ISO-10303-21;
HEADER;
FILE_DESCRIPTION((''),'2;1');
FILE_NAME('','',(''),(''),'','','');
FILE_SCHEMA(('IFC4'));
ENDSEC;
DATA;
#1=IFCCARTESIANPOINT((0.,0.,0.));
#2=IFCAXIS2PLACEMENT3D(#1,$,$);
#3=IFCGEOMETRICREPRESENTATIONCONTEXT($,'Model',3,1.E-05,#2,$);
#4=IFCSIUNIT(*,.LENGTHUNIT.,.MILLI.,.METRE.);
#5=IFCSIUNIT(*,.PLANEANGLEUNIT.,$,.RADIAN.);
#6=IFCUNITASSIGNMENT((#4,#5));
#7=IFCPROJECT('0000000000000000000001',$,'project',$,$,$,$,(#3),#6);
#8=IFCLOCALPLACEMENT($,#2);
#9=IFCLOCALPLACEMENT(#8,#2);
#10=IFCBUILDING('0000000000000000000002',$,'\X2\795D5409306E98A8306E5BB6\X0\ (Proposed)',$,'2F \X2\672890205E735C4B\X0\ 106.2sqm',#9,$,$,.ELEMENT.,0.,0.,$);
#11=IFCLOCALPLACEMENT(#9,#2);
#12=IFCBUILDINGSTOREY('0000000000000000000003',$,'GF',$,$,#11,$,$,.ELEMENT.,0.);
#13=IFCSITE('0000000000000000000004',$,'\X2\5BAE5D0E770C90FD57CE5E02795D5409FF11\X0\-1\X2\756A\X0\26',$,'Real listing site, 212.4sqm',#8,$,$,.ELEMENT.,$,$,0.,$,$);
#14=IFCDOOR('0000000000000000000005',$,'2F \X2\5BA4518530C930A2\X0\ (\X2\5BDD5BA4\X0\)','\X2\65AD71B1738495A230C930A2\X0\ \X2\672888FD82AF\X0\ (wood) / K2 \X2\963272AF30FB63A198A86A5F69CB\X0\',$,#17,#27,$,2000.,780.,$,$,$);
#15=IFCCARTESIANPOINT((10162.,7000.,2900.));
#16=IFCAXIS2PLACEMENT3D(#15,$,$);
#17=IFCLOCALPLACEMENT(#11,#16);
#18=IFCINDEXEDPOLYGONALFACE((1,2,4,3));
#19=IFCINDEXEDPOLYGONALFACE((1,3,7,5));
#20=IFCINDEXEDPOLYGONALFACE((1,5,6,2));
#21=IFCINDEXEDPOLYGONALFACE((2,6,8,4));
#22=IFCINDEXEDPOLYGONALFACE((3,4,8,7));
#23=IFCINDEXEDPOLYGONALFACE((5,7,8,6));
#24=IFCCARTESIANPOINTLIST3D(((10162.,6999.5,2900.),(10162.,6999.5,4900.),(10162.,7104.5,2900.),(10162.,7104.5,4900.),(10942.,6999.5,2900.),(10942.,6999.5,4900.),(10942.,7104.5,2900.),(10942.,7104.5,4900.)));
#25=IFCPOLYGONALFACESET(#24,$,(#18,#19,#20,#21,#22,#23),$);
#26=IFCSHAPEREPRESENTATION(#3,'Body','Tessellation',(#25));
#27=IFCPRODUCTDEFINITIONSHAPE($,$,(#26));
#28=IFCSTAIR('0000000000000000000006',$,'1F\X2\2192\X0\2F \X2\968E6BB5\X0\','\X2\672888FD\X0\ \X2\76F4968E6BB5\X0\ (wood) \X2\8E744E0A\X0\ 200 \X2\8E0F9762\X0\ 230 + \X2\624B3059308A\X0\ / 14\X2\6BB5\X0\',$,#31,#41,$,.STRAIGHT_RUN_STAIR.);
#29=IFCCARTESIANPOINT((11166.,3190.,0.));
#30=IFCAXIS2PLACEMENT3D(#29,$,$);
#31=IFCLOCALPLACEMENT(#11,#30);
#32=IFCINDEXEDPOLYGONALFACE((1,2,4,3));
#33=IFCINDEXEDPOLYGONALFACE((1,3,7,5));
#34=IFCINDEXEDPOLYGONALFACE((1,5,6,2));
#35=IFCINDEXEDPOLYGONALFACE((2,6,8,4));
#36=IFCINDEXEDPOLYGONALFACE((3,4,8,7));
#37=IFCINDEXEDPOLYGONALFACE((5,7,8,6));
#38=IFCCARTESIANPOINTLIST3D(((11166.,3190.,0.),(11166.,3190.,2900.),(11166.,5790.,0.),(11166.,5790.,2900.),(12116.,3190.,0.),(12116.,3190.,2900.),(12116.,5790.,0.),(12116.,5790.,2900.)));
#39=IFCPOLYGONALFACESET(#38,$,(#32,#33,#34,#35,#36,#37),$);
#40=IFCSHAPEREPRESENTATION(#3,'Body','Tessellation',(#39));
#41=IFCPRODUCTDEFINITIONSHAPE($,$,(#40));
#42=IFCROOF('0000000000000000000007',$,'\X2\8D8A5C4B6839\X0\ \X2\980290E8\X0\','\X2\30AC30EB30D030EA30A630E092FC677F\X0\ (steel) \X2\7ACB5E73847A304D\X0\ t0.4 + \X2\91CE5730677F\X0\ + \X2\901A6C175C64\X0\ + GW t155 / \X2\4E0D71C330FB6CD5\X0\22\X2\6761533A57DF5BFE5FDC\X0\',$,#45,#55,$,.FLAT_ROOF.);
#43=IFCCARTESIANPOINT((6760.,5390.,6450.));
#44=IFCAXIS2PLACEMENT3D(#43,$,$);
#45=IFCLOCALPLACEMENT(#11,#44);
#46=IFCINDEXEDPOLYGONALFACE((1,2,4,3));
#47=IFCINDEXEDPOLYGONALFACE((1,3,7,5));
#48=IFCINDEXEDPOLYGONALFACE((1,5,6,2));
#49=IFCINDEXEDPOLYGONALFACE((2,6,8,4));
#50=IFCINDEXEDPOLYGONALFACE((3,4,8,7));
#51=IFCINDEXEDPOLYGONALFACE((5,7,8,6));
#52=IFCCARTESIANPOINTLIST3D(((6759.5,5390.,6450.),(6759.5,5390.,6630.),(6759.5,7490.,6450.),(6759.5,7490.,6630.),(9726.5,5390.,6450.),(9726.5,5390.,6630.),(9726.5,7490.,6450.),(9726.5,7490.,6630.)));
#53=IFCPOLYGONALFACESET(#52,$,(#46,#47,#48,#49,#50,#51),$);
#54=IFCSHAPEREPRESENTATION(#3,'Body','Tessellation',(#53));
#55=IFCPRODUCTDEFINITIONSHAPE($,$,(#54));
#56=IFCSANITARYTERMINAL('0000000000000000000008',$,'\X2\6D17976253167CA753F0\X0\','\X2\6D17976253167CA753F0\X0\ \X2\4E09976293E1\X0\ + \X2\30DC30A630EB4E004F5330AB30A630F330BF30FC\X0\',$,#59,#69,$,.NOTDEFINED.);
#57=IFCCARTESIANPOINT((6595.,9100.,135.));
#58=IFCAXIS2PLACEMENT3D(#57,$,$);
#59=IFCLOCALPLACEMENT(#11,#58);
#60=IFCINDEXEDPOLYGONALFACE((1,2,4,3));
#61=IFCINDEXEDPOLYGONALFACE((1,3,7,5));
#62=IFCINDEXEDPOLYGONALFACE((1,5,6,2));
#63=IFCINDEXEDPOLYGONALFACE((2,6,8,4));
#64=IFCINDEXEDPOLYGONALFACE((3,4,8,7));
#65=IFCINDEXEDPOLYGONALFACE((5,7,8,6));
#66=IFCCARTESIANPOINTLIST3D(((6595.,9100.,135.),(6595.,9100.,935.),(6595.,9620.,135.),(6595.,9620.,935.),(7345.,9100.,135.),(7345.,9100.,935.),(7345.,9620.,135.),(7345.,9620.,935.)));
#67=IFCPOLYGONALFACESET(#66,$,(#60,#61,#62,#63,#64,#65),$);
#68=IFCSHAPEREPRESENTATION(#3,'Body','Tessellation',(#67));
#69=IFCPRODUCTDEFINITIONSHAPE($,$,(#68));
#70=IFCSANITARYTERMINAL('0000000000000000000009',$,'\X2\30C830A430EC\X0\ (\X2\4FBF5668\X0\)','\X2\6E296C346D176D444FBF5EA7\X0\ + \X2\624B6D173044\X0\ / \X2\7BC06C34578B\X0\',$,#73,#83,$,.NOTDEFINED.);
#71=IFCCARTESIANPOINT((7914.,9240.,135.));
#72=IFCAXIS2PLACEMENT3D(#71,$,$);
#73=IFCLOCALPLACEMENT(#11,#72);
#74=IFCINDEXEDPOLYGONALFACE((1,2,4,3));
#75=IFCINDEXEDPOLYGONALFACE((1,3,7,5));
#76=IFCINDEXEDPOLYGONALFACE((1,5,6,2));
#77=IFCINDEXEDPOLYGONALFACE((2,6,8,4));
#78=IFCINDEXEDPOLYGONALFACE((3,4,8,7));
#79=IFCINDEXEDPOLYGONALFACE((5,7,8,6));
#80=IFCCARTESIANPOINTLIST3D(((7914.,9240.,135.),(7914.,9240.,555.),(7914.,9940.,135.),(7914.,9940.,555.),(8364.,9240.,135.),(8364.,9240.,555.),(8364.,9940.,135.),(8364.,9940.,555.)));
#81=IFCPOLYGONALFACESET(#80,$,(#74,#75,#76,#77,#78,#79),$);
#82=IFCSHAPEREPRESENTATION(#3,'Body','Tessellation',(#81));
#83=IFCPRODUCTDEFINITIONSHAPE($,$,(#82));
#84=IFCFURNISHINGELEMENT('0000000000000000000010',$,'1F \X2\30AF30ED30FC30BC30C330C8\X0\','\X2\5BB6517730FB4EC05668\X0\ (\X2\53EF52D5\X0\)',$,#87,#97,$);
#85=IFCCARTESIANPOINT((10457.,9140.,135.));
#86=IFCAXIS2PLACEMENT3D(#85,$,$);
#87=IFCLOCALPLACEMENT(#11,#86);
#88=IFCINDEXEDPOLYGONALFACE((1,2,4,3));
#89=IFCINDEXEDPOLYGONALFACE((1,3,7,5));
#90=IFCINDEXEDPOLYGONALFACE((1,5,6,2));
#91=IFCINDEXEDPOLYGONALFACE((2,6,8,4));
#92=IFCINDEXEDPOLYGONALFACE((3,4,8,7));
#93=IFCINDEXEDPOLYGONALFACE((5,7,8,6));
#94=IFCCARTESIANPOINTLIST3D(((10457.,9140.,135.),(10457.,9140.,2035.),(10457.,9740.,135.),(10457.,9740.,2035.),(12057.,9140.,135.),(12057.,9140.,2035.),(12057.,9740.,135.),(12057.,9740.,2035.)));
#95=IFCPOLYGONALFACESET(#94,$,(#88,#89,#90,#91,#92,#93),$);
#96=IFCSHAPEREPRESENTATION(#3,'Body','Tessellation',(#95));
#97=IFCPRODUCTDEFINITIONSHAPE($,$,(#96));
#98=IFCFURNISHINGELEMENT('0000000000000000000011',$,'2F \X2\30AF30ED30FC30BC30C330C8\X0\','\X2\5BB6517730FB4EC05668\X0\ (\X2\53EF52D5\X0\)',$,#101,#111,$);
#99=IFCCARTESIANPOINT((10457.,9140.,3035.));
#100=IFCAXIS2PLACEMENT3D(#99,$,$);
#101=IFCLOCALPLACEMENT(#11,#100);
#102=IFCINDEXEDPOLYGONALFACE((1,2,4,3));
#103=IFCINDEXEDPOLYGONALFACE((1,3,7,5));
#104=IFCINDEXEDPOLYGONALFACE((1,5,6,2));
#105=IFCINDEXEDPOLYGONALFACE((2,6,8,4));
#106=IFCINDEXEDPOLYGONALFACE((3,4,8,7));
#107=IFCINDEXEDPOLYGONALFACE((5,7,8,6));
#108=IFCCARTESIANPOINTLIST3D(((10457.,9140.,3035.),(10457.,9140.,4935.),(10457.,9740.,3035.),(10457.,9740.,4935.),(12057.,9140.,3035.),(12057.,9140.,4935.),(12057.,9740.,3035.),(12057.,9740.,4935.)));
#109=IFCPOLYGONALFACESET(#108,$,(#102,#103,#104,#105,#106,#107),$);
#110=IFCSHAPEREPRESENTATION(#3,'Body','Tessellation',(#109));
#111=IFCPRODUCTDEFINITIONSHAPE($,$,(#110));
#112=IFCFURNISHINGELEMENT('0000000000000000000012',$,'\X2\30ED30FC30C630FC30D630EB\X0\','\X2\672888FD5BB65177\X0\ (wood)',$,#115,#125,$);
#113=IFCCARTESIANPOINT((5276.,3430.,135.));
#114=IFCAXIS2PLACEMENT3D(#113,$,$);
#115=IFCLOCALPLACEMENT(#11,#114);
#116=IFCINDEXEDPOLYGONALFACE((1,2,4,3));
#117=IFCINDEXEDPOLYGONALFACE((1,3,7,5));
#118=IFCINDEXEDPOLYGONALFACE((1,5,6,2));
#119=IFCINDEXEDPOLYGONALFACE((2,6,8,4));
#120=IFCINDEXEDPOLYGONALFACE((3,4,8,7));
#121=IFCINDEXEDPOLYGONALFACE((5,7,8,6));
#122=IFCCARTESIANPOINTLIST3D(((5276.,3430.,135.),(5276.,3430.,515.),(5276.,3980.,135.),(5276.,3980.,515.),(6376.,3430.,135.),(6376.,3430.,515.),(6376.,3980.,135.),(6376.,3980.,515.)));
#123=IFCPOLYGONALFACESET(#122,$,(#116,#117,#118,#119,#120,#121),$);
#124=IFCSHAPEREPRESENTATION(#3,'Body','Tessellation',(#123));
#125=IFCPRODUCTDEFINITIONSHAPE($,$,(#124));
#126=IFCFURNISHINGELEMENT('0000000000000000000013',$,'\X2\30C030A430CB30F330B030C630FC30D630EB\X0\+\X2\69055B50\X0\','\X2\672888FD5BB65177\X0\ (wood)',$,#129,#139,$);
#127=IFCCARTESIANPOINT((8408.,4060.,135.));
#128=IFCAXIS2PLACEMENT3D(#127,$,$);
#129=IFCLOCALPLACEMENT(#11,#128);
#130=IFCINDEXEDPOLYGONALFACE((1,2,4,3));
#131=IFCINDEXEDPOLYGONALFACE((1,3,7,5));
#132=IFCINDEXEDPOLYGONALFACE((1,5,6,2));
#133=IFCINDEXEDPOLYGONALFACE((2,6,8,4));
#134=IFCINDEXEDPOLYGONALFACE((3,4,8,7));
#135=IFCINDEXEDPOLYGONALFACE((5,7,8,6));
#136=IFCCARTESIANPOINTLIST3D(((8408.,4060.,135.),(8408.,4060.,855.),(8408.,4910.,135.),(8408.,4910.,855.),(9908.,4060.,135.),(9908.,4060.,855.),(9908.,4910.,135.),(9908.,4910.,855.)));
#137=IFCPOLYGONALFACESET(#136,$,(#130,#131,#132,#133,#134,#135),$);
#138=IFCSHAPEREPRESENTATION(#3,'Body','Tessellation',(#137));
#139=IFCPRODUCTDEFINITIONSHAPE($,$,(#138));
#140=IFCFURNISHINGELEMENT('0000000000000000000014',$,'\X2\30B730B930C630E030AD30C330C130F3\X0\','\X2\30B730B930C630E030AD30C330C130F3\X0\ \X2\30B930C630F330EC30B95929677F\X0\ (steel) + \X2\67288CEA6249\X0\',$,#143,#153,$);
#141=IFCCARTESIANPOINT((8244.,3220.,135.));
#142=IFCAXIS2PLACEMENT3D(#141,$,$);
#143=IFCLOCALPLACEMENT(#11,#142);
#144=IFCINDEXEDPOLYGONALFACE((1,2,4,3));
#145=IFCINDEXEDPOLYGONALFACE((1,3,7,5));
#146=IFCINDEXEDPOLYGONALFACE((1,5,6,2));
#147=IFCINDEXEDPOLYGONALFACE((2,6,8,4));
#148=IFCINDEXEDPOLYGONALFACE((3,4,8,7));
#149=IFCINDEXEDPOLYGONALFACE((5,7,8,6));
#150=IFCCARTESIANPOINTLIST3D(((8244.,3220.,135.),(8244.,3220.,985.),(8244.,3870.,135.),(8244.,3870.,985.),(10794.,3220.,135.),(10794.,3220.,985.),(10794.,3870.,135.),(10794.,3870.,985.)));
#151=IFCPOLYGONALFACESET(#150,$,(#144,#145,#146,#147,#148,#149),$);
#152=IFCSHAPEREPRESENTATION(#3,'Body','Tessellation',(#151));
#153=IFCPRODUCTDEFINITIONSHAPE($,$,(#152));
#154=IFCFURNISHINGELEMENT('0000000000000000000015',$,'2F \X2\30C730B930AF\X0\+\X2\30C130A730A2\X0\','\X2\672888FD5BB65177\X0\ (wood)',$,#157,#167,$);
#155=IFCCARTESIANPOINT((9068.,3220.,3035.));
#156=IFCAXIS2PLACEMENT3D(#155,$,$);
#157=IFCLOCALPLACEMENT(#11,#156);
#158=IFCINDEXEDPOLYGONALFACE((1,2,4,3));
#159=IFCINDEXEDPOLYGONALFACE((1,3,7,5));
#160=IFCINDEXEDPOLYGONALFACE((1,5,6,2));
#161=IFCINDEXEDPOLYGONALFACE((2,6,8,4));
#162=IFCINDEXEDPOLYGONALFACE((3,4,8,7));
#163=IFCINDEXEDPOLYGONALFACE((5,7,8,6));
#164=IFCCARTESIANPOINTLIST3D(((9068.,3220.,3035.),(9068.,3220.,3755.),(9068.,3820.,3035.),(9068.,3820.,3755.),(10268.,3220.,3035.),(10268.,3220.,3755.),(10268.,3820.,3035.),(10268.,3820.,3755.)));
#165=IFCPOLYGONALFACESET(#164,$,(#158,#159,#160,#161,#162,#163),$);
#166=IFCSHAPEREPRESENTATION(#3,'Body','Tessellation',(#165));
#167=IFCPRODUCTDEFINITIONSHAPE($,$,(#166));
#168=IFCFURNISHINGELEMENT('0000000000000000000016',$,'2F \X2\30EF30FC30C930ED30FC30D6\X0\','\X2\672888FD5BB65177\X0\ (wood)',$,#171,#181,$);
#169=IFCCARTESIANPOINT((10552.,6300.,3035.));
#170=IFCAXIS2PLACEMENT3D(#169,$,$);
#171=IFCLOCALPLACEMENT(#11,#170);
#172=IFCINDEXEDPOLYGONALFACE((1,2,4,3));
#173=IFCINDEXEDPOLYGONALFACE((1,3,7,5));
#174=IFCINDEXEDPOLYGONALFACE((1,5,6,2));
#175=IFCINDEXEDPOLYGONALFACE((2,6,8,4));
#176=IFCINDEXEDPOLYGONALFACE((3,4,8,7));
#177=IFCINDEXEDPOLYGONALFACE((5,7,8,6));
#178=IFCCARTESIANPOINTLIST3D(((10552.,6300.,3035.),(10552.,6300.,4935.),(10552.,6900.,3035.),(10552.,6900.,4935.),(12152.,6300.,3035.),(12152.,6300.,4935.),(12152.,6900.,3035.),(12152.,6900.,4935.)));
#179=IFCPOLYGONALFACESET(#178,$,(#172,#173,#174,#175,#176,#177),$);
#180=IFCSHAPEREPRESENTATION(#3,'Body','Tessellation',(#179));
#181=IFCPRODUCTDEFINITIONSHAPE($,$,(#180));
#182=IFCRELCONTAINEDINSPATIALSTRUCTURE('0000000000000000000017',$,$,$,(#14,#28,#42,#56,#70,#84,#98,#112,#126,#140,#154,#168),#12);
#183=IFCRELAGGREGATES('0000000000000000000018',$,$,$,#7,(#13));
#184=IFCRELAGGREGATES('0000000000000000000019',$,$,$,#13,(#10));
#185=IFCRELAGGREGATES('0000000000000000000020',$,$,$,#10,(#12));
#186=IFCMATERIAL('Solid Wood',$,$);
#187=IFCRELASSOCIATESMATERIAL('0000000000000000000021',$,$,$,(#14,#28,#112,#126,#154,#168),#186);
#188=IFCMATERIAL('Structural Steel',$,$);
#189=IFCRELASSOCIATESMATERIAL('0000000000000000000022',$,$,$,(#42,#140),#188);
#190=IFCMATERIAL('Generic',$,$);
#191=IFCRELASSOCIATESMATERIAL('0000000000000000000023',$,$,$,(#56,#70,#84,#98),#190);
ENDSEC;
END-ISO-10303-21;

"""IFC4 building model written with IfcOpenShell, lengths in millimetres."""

from ifc_helpers import new_model, si_unit, frame, frame_2d, origin, place, context, project, spatial, rectangle, extrude, material, element, save


model = new_model("IFC4")

# Units and contexts
model_context = context("Model", 3, precision=1e-05, world=origin())
ifc_project = project(units=[si_unit("LENGTHUNIT", "METRE", prefix="MILLI"), si_unit("PLANEANGLEUNIT", "RADIAN")], contexts=[model_context])

# Site, building, storey
site_placement = place(None, origin())
site = spatial("IfcSite", under=ifc_project, at=site_placement, Name="宮崎県都城市祝吉１-1番26", ObjectType="Real listing site, 212.4sqm", CompositionType="ELEMENT", RefElevation=0.0)
building_placement = place(site_placement, origin())
building = spatial("IfcBuilding", under=site, at=building_placement, Name="祝吉の風の家 (Proposed)", ObjectType="2F 木造平屋 106.2sqm", CompositionType="ELEMENT", ElevationOfRefHeight=0.0, ElevationOfTerrain=0.0)
storey_placement = place(building_placement, origin())
storey = spatial("IfcBuildingStorey", under=building, at=storey_placement, Name="GF", CompositionType="ELEMENT", Elevation=0.0)

# Shared definitions
ifc_material_1 = material(Name="Solid Wood")

# Door
door_1_placement = place(storey_placement, frame((10162.0, 7000.0, 2900.0)))
element("IfcDoor", 1, at=door_1_placement, inside=storey, material=ifc_material_1, Name="2F 室内ドア (寝室)", Description="断熱玄関ドア 木製芯 (wood) / K2 防犯・採風機構", OverallHeight=2000.0, OverallWidth=780.0, context=model_context, shape_type="SweptSolid", body=[
    extrude(rectangle(XDim=780.0, YDim=105.0, at=frame_2d((390.0, 52.0))), frame((10162.0, 7000.0, 2900.0)), (0.0, 0.0, 1.0), 2000.0),
])

# Stair
stair_placement = place(storey_placement, frame((11166.0, 3190.0, 0.0)))
element("IfcStair", 2, at=stair_placement, inside=storey, material=ifc_material_1, Name="1F→2F 階段", Description="木製 直階段 (wood) 蹴上 200 踏面 230 + 手すり / 14段", PredefinedType="STRAIGHT_RUN_STAIR", context=model_context, shape_type="SweptSolid", body=[
    extrude(rectangle(XDim=950.0, YDim=2600.0, at=frame_2d((475.0, 1300.0))), frame((11166.0, 3190.0, 0.0)), (0.0, 0.0, 1.0), 2900.0),
])

# Roof
ifc_material_2 = material(Name="Structural Steel")
roof_placement = place(storey_placement, frame((6760.0, 5390.0, 6450.0)))
element("IfcRoof", 3, at=roof_placement, inside=storey, material=ifc_material_2, Name="越屋根 頂部", Description="ガルバリウム鋼板 (steel) 立平葺き t0.4 + 野地板 + 通気層 + GW t155 / 不燃・法22条区域対応", PredefinedType="FLAT_ROOF", context=model_context, shape_type="SweptSolid", body=[
    extrude(rectangle(XDim=2967.0, YDim=2100.0, at=frame_2d((1483.0, 1050.0))), frame((6760.0, 5390.0, 6450.0)), (0.0, 0.0, 1.0), 180.0),
])

# Sanitary terminals
ifc_material_3 = material(Name="Generic")
sanitary_terminal_1_placement = place(storey_placement, frame((6595.0, 9100.0, 135.0)))
element("IfcSanitaryTerminal", 4, at=sanitary_terminal_1_placement, inside=storey, material=ifc_material_3, Name="洗面化粧台", Description="洗面化粧台 三面鏡 + ボウル一体カウンター", PredefinedType="NOTDEFINED", context=model_context, shape_type="SweptSolid", body=[
    extrude(rectangle(XDim=750.0, YDim=520.0, at=frame_2d((375.0, 260.0))), frame((6595.0, 9100.0, 135.0)), (0.0, 0.0, 1.0), 800.0),
])
sanitary_terminal_2_placement = place(storey_placement, frame((7914.0, 9240.0, 135.0)))
element("IfcSanitaryTerminal", 5, at=sanitary_terminal_2_placement, inside=storey, material=ifc_material_3, Name="トイレ (便器)", Description="温水洗浄便座 + 手洗い / 節水型", PredefinedType="NOTDEFINED", context=model_context, shape_type="SweptSolid", body=[
    extrude(rectangle(XDim=450.0, YDim=700.0, at=frame_2d((225.0, 350.0))), frame((7914.0, 9240.0, 135.0)), (0.0, 0.0, 1.0), 420.0),
])

# Furnishing elements
furnishing_1_placement = place(storey_placement, frame((10457.0, 9140.0, 135.0)))
element("IfcFurnishingElement", 6, at=furnishing_1_placement, inside=storey, material=ifc_material_3, Name="1F クローゼット", Description="家具・什器 (可動)", context=model_context, shape_type="SweptSolid", body=[
    extrude(rectangle(XDim=1600.0, YDim=600.0, at=frame_2d((800.0, 300.0))), frame((10457.0, 9140.0, 135.0)), (0.0, 0.0, 1.0), 1900.0),
])
furnishing_2_placement = place(storey_placement, frame((10457.0, 9140.0, 3035.0)))
element("IfcFurnishingElement", 7, at=furnishing_2_placement, inside=storey, material=ifc_material_3, Name="2F クローゼット", Description="家具・什器 (可動)", context=model_context, shape_type="SweptSolid", body=[
    extrude(rectangle(XDim=1600.0, YDim=600.0, at=frame_2d((800.0, 300.0))), frame((10457.0, 9140.0, 3035.0)), (0.0, 0.0, 1.0), 1900.0),
])
furnishing_3_placement = place(storey_placement, frame((5276.0, 3430.0, 135.0)))
element("IfcFurnishingElement", 8, at=furnishing_3_placement, inside=storey, material=ifc_material_1, Name="ローテーブル", Description="木製家具 (wood)", context=model_context, shape_type="SweptSolid", body=[
    extrude(rectangle(XDim=1100.0, YDim=550.0, at=frame_2d((550.0, 275.0))), frame((5276.0, 3430.0, 135.0)), (0.0, 0.0, 1.0), 380.0),
])
furnishing_4_placement = place(storey_placement, frame((8408.0, 4060.0, 135.0)))
element("IfcFurnishingElement", 9, at=furnishing_4_placement, inside=storey, material=ifc_material_1, Name="ダイニングテーブル+椅子", Description="木製家具 (wood)", context=model_context, shape_type="SweptSolid", body=[
    extrude(rectangle(XDim=1500.0, YDim=850.0, at=frame_2d((750.0, 425.0))), frame((8408.0, 4060.0, 135.0)), (0.0, 0.0, 1.0), 720.0),
])
furnishing_5_placement = place(storey_placement, frame((8244.0, 3220.0, 135.0)))
element("IfcFurnishingElement", 10, at=furnishing_5_placement, inside=storey, material=ifc_material_2, Name="システムキッチン", Description="システムキッチン ステンレス天板 (steel) + 木質扉", context=model_context, shape_type="SweptSolid", body=[
    extrude(rectangle(XDim=2550.0, YDim=650.0, at=frame_2d((1275.0, 325.0))), frame((8244.0, 3220.0, 135.0)), (0.0, 0.0, 1.0), 850.0),
])
furnishing_6_placement = place(storey_placement, frame((9068.0, 3220.0, 3035.0)))
element("IfcFurnishingElement", 11, at=furnishing_6_placement, inside=storey, material=ifc_material_1, Name="2F デスク+チェア", Description="木製家具 (wood)", context=model_context, shape_type="SweptSolid", body=[
    extrude(rectangle(XDim=1200.0, YDim=600.0, at=frame_2d((600.0, 300.0))), frame((9068.0, 3220.0, 3035.0)), (0.0, 0.0, 1.0), 720.0),
])
furnishing_7_placement = place(storey_placement, frame((10552.0, 6300.0, 3035.0)))
element("IfcFurnishingElement", 12, at=furnishing_7_placement, inside=storey, material=ifc_material_1, Name="2F ワードローブ", Description="木製家具 (wood)", context=model_context, shape_type="SweptSolid", body=[
    extrude(rectangle(XDim=1600.0, YDim=600.0, at=frame_2d((800.0, 300.0))), frame((10552.0, 6300.0, 3035.0)), (0.0, 0.0, 1.0), 1900.0),
])

save(model, "model.ifc")
